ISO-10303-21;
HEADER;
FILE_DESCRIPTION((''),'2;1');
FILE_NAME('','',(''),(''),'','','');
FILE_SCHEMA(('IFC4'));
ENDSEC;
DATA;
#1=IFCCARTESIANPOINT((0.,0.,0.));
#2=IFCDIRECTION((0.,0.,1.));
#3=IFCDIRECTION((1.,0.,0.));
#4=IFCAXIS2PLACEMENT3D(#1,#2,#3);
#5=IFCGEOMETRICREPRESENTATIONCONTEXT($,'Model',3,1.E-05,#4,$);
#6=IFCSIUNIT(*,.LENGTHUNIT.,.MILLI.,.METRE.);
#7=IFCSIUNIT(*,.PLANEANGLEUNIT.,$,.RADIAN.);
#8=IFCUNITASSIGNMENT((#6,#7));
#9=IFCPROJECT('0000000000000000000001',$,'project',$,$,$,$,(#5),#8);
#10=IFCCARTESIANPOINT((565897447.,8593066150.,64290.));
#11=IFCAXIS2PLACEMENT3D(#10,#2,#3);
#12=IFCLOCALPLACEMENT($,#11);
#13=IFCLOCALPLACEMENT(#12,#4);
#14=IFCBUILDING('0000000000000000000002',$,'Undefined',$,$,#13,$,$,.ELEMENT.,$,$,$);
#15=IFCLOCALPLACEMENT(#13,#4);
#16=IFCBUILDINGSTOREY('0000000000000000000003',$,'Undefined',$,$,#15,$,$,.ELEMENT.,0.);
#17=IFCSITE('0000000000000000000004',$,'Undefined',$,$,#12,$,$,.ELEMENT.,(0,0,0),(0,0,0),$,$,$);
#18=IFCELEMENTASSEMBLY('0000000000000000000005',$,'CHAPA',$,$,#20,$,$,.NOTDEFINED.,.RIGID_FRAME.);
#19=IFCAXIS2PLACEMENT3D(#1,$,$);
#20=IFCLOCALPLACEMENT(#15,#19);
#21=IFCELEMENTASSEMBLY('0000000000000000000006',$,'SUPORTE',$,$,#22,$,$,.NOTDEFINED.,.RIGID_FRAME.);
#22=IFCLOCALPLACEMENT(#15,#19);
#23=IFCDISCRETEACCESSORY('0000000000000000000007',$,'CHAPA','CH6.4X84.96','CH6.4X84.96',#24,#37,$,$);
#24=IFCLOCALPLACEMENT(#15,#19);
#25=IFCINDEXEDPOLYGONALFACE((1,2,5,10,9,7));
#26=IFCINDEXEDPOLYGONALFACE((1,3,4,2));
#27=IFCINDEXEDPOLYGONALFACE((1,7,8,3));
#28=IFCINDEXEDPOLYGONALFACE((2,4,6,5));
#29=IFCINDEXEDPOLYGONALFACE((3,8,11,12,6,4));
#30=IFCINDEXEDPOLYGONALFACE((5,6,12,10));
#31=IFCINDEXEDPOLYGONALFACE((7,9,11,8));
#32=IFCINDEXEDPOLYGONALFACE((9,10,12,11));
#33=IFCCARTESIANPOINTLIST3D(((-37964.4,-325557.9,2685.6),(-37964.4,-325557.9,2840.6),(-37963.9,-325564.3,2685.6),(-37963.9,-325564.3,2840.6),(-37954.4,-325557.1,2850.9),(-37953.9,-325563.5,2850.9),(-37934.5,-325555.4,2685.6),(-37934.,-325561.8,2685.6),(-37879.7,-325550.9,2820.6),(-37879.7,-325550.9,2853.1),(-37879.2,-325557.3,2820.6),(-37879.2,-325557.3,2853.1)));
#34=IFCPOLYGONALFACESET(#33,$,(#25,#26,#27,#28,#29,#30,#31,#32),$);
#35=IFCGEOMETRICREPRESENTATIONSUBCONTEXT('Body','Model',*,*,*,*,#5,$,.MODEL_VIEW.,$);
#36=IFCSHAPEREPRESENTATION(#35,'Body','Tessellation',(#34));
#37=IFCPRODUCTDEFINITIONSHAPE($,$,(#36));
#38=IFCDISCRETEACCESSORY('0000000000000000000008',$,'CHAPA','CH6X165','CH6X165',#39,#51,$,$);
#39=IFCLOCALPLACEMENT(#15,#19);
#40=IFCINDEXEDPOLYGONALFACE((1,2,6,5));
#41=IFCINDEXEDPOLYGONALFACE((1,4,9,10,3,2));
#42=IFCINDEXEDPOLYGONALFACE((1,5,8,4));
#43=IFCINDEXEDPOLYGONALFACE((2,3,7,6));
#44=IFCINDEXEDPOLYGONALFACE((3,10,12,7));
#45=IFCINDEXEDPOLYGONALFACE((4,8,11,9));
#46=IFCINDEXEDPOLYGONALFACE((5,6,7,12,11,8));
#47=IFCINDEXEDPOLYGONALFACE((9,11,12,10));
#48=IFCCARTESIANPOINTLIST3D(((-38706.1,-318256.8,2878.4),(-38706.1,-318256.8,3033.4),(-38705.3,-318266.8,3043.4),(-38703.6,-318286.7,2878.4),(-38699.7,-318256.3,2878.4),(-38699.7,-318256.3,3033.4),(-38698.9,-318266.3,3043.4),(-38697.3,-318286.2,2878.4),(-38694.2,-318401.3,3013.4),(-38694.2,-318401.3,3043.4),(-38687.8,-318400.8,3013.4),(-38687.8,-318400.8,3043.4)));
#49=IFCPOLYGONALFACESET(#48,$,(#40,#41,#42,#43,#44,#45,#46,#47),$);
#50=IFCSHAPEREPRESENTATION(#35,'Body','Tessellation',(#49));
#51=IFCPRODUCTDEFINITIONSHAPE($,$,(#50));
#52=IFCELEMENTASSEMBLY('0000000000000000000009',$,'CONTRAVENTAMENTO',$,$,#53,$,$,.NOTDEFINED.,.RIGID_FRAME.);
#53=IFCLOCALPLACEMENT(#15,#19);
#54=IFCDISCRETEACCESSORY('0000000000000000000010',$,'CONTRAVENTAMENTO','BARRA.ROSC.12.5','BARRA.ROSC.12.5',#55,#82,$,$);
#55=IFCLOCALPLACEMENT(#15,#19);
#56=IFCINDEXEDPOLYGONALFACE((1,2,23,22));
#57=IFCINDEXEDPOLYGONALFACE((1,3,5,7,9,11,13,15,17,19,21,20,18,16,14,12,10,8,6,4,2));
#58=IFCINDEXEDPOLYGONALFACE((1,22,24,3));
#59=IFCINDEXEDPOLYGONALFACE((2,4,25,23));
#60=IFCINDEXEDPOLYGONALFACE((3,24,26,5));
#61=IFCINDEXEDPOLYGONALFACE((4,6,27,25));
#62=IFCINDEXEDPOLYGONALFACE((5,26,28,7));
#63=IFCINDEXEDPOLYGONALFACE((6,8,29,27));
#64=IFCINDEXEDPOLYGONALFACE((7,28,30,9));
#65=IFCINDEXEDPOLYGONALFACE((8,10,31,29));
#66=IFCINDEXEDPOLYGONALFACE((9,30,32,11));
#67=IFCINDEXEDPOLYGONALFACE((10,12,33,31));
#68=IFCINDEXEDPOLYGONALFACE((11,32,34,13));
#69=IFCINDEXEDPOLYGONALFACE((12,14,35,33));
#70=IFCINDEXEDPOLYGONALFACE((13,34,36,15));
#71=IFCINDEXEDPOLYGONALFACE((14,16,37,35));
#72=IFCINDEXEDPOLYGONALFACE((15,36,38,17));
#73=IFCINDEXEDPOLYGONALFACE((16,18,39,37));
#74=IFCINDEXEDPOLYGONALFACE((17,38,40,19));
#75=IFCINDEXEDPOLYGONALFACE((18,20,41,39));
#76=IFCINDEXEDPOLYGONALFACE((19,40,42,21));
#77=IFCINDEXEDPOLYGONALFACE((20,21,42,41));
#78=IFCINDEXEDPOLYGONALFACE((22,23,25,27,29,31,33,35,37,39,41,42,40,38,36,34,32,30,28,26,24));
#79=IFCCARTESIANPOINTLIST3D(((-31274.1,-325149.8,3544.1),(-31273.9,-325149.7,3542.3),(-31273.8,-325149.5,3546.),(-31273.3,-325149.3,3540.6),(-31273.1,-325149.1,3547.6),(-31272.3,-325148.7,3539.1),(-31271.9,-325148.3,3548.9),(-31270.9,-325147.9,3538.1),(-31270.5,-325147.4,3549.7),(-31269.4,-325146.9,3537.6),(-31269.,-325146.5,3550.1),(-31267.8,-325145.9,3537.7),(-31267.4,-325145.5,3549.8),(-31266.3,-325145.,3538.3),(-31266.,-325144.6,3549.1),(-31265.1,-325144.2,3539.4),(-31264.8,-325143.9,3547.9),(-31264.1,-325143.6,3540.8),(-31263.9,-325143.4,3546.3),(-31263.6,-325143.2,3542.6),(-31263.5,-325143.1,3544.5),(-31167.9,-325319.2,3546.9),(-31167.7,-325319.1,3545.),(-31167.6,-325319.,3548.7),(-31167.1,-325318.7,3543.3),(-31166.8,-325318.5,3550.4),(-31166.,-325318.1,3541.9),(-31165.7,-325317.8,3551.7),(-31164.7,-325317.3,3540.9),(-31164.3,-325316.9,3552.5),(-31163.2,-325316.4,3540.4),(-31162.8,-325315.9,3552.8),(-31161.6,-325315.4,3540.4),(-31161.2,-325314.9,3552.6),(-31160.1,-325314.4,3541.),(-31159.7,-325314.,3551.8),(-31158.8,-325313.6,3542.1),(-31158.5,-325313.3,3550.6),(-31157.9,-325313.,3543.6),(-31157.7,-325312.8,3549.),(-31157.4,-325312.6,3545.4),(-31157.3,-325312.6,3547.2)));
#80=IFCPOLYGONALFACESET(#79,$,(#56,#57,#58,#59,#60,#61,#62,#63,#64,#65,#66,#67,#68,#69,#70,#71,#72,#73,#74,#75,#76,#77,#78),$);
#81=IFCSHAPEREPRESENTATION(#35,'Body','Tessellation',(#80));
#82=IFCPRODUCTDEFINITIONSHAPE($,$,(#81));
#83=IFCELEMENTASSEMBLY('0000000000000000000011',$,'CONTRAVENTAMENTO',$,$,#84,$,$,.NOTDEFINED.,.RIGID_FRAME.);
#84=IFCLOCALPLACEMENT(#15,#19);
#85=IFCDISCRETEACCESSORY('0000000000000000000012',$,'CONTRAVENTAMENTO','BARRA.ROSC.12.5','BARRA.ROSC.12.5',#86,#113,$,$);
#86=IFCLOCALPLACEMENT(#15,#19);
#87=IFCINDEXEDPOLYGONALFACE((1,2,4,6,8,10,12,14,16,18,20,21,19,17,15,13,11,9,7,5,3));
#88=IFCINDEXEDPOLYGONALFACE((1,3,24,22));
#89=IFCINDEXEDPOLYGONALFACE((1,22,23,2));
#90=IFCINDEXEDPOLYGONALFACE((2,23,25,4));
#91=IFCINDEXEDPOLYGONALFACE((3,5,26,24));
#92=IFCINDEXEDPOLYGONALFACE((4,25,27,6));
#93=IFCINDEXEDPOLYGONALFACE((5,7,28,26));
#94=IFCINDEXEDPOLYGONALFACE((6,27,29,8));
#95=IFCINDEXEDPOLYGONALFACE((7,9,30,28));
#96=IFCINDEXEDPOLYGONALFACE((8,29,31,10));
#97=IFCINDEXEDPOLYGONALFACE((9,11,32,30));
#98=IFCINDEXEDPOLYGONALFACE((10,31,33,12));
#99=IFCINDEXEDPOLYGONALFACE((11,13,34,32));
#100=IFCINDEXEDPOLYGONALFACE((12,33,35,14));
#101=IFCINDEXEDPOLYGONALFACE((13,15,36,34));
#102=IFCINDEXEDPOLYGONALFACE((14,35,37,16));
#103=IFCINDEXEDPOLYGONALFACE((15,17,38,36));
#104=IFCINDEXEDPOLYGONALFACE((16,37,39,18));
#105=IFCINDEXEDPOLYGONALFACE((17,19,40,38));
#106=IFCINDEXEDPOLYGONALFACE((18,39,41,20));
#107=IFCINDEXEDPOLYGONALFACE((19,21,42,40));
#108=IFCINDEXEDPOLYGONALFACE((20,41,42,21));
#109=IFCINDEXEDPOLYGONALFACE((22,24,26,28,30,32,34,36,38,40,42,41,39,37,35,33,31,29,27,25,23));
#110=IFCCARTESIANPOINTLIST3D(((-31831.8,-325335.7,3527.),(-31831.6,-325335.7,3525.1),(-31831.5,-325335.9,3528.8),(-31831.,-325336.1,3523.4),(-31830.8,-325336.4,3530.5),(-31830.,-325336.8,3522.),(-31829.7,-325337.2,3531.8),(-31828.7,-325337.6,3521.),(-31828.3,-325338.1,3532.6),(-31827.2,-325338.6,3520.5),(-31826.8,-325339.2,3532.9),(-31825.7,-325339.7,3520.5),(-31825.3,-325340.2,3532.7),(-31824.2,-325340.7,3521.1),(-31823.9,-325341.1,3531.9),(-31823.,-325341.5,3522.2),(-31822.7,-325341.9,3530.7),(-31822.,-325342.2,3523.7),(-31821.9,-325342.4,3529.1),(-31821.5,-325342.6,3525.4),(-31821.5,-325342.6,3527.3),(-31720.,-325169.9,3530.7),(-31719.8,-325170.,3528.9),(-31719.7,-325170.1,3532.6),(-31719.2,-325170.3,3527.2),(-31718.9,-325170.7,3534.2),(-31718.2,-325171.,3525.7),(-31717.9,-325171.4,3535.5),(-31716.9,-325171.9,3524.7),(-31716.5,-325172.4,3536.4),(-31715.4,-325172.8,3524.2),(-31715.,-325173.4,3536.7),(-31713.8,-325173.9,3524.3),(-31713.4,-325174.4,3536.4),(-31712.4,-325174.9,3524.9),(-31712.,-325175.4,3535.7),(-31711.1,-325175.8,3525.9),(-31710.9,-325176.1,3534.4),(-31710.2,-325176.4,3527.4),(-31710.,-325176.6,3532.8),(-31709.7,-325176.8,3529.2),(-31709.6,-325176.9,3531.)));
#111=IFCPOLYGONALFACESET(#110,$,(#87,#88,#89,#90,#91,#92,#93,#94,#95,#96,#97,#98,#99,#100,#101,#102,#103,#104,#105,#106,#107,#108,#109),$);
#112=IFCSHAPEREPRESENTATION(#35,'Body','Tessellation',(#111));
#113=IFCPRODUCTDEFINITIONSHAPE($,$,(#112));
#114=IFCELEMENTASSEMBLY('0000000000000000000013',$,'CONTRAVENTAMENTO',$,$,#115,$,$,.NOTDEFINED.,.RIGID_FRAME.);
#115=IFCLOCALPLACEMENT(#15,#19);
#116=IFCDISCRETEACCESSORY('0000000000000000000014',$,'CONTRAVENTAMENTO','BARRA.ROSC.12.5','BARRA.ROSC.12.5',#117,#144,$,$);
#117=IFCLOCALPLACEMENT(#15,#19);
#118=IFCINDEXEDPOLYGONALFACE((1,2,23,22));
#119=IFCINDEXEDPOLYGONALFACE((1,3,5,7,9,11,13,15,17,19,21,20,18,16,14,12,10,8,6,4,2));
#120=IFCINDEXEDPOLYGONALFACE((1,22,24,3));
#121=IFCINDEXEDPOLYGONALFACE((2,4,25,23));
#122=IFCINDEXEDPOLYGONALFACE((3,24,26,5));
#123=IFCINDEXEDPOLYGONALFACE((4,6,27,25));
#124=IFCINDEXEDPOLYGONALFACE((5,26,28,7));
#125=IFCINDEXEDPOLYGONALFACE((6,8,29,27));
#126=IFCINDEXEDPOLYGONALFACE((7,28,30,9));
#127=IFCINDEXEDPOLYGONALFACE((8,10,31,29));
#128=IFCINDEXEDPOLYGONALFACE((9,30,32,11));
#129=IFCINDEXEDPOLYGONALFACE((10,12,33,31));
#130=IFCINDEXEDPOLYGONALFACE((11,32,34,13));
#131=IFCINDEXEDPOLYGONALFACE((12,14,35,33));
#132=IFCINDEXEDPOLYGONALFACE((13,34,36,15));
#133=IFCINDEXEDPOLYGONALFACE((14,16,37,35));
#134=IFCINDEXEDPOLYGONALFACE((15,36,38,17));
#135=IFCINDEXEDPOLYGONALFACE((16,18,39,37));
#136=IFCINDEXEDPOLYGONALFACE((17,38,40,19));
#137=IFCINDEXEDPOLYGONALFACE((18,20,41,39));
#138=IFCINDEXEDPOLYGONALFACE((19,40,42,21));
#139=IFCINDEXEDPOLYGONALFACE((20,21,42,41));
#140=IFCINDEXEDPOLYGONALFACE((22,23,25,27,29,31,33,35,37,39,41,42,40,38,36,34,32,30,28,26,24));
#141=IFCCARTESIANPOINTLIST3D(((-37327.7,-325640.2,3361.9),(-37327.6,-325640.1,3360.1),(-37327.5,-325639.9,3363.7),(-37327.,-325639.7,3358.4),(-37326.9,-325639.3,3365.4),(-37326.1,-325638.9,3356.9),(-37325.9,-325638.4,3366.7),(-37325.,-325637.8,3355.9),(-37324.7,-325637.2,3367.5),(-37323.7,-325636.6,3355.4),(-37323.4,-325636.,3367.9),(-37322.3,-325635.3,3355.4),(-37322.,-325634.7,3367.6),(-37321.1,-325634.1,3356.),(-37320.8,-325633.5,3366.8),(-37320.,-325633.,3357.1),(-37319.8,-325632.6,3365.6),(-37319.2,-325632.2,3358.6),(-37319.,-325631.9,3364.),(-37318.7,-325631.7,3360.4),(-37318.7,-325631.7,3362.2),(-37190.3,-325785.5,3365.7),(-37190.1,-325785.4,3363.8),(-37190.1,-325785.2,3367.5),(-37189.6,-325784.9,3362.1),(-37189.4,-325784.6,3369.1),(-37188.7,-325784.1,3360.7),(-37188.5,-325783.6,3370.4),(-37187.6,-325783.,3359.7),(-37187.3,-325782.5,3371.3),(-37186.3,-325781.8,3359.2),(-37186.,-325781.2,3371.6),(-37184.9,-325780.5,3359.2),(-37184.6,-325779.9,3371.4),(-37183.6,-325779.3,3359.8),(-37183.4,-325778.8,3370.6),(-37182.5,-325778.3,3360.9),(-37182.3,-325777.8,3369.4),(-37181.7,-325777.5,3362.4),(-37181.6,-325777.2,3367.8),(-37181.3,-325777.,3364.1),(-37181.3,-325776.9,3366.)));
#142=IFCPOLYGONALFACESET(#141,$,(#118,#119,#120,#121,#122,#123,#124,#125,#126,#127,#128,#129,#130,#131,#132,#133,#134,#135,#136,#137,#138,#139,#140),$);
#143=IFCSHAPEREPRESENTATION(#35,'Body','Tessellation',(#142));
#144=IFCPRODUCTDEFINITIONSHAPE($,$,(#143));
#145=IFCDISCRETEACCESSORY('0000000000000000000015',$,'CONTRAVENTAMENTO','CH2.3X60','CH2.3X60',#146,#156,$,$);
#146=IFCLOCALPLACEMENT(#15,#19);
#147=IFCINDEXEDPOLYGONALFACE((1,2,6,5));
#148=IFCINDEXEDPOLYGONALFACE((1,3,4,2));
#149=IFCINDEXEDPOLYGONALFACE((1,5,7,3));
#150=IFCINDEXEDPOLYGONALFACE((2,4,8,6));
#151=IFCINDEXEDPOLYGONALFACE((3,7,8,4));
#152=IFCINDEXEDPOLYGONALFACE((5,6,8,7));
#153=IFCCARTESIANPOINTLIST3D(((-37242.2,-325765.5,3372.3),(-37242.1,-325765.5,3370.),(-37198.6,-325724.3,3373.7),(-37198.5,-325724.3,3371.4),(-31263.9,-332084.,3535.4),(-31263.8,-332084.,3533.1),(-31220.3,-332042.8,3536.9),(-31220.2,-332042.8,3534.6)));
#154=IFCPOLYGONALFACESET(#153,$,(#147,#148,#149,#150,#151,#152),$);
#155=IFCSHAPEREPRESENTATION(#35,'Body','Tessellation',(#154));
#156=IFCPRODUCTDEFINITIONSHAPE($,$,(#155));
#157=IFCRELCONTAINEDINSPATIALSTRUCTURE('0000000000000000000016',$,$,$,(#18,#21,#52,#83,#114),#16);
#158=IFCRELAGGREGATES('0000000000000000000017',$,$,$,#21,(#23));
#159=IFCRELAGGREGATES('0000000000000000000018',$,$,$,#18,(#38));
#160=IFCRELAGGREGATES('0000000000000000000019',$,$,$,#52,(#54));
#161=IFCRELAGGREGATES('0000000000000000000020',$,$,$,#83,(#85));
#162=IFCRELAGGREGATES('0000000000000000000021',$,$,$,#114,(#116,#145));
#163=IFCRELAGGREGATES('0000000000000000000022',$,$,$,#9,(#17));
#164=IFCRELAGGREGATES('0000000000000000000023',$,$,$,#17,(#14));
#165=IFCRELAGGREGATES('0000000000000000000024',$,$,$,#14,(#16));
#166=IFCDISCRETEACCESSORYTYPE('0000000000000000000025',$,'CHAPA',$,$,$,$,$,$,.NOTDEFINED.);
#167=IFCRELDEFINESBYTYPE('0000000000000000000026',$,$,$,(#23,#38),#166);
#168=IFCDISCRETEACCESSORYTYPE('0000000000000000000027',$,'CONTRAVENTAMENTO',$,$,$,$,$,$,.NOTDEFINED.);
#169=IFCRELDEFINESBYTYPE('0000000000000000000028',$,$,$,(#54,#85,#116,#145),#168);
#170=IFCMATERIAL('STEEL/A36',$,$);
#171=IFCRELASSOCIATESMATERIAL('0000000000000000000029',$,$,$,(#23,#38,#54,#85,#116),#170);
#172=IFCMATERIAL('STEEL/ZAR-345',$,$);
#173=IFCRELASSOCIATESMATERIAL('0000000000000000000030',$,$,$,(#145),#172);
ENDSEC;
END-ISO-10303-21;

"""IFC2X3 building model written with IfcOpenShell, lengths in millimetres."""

from ifc_helpers import new_model, si_unit, frame, origin_with_axes, origin_2d_with_axis, place, context, subcontext, project, spatial, polyline, circle, outline, extrude, material, type_object, element, aggregate, save


model = new_model("IFC2X3")

# Units and contexts
model_context = context("Model", 3, precision=1e-05, world=origin_with_axes())
body_context = subcontext(model_context, "Body", "Model", "MODEL_VIEW")
ifc_project = project(units=[si_unit("LENGTHUNIT", "METRE", prefix="MILLI"), si_unit("PLANEANGLEUNIT", "RADIAN")], contexts=[model_context])

# Site, building, storey
site_placement = place(None, frame((565897447.0, 8593066150.0, 64290.0), z_axis=(0.0, 0.0, 1.0), x_axis=(1.0, 0.0, 0.0)))
site = spatial("IfcSite", under=ifc_project, at=site_placement, Name="Undefined", CompositionType="ELEMENT", RefLatitude=(0, 0, 0), RefLongitude=(0, 0, 0))
building_placement = place(site_placement, origin_with_axes())
building = spatial("IfcBuilding", under=site, at=building_placement, Name="Undefined", CompositionType="ELEMENT")
storey_placement = place(building_placement, origin_with_axes())
storey = spatial("IfcBuildingStorey", under=building, at=storey_placement, Name="Undefined", CompositionType="ELEMENT", Elevation=0.0)

# Element assembly
ifc_material_1 = material(Name="STEEL/A36")
assembly_1_placement = place(storey_placement, origin_with_axes())
assembly_1 = element("IfcElementAssembly", 1, at=assembly_1_placement, inside=storey, Name="CHAPA", AssemblyPlace="NOTDEFINED", PredefinedType="RIGID_FRAME")

# Shared definitions
discrete_accessory_type_1 = type_object("IfcDiscreteAccessoryType", Name="CHAPA")

# Element assembly, discrete accessory
assembly_2_placement = place(storey_placement, origin_with_axes())
assembly_2 = element("IfcElementAssembly", 2, at=assembly_2_placement, inside=storey, Name="SUPORTE", AssemblyPlace="NOTDEFINED", PredefinedType="RIGID_FRAME")
discrete_accessory_1_placement = place(assembly_2_placement, frame((-37964.1, -325561.1, 2850.6), z_axis=(0.082025, -0.99663, 0.0), x_axis=(0.0, 0.0, -1.0)))
discrete_accessory_1 = element("IfcDiscreteAccessory", 3, at=discrete_accessory_1_placement, type_object=discrete_accessory_type_1, material=ifc_material_1, Name="CHAPA", Description="CH6.4X84.96", ObjectType="CH6.4X84.96", context=body_context, shape_type="SweptSolid", body=[
    extrude(outline(polyline([(-0.3, 10.0), (10.0, 0.0), (165.0, 0.0), (165.0, 30.0), (30.0, 85.0), (-2.5, 85.0), (-0.3, 10.0)])), frame((0.0, 0.0, -3.2), z_axis=(0.0, 0.0, 1.0), x_axis=(1.0, 0.0, 0.0)), (0.0, 0.0, 1.0), 6.4),
])
aggregate(assembly_2, [discrete_accessory_1])

# Discrete accessory
discrete_accessory_2_placement = place(assembly_1_placement, frame((-38702.9, -318256.6, 3043.4), z_axis=(-0.99663, -0.082025, 0.000004), x_axis=(-0.000004, 0.0, -1.0)))
discrete_accessory_2 = element("IfcDiscreteAccessory", 4, at=discrete_accessory_2_placement, type_object=discrete_accessory_type_1, material=ifc_material_1, Name="CHAPA", Description="CH6X165", ObjectType="CH6X165", context=body_context, shape_type="SweptSolid", body=[
    extrude(outline(polyline([(0.0, 10.0), (10.0, 0.0), (165.0, 0.0), (165.0, 30.0), (30.0, 145.0), (0.0, 145.0), (0.0, 10.0)])), frame((0.0, 0.0, -3.2), z_axis=(0.0, 0.0, 1.0), x_axis=(1.0, 0.0, 0.0)), (0.0, 0.0, 1.0), 6.4),
])
aggregate(assembly_1, [discrete_accessory_2])

# Element assemblies, discrete accessories
assembly_3_placement = place(storey_placement, origin_with_axes())
assembly_3 = element("IfcElementAssembly", 5, at=assembly_3_placement, inside=storey, Name="CONTRAVENTAMENTO", AssemblyPlace="NOTDEFINED", PredefinedType="RIGID_FRAME")
discrete_accessory_type_2 = type_object("IfcDiscreteAccessoryType", Name="CONTRAVENTAMENTO")
discrete_accessory_3_placement = place(assembly_3_placement, frame((-31268.8, -325146.4, 3543.8), z_axis=(0.84672, 0.531363, 0.026799), x_axis=(0.53119, -0.84714, 0.013797)))
discrete_accessory_3 = element("IfcDiscreteAccessory", 6, at=discrete_accessory_3_placement, type_object=discrete_accessory_type_2, material=ifc_material_1, Name="CONTRAVENTAMENTO", Description="BARRA.ROSC.12.5", ObjectType="BARRA.ROSC.12.5", context=body_context, shape_type="SweptSolid", body=[
    extrude(circle(Radius=6.2, at=origin_2d_with_axis()), frame((200.0, 0.0, 0.0), z_axis=(-1.0, 0.0, 0.0), x_axis=(0.0, -1.0, 0.0)), (0.0, 0.0, 1.0), 200.0),
])
aggregate(assembly_3, [discrete_accessory_3])
assembly_4_placement = place(storey_placement, origin_with_axes())
assembly_4 = element("IfcElementAssembly", 7, at=assembly_4_placement, inside=storey, Name="CONTRAVENTAMENTO", AssemblyPlace="NOTDEFINED", PredefinedType="RIGID_FRAME")
discrete_accessory_4_placement = place(assembly_4_placement, frame((-31714.8, -325173.4, 3530.4), z_axis=(0.828505, -0.559481, 0.023679), x_axis=(-0.559171, -0.82884, -0.018758)))
discrete_accessory_4 = element("IfcDiscreteAccessory", 8, at=discrete_accessory_4_placement, type_object=discrete_accessory_type_2, material=ifc_material_1, Name="CONTRAVENTAMENTO", Description="BARRA.ROSC.12.5", ObjectType="BARRA.ROSC.12.5", context=body_context, shape_type="SweptSolid", body=[
    extrude(circle(Radius=6.2, at=origin_2d_with_axis()), frame((200.0, 0.0, 0.0), z_axis=(-1.0, 0.0, 0.0), x_axis=(0.0, -1.0, 0.0)), (0.0, 0.0, 1.0), 200.0),
])
aggregate(assembly_4, [discrete_accessory_4])

# Element assembly, discrete accessories
assembly_5_placement = place(storey_placement, origin_with_axes())
assembly_5 = element("IfcElementAssembly", 9, at=assembly_5_placement, inside=storey, Name="CONTRAVENTAMENTO", AssemblyPlace="NOTDEFINED", PredefinedType="RIGID_FRAME")
discrete_accessory_5_placement = place(assembly_5_placement, frame((-37323.2, -325635.9, 3361.6), z_axis=(0.725882, 0.687412, 0.023679), x_axis=(0.687161, -0.726263, 0.018758)))
discrete_accessory_5 = element("IfcDiscreteAccessory", 10, at=discrete_accessory_5_placement, type_object=discrete_accessory_type_2, material=ifc_material_1, Name="CONTRAVENTAMENTO", Description="BARRA.ROSC.12.5", ObjectType="BARRA.ROSC.12.5", context=body_context, shape_type="SweptSolid", body=[
    extrude(circle(Radius=6.2, at=origin_2d_with_axis()), frame((200.0, 0.0, 0.0), z_axis=(-1.0, 0.0, 0.0), x_axis=(0.0, -1.0, 0.0)), (0.0, 0.0, 1.0), 200.0),
])
ifc_material_2 = material(Name="STEEL/ZAR-345")
discrete_accessory_6_placement = place(assembly_5_placement, frame((-37220.3, -325744.9, 3371.8), z_axis=(-0.030092, -0.002655, 0.999544), x_axis=(0.687161, -0.726263, 0.018758)))
discrete_accessory_6 = element("IfcDiscreteAccessory", 11, at=discrete_accessory_6_placement, type_object=discrete_accessory_type_2, material=ifc_material_2, Name="CONTRAVENTAMENTO", Description="CH2.3X60", ObjectType="CH2.3X60", context=body_context, shape_type="SweptSolid", body=[
    extrude(outline(polyline([(0.0, 30.0), (8700.0, 30.0), (8700.0, -30.0), (0.0, -30.0), (0.0, 30.0)])), frame((0.0, 0.0, -1.1), z_axis=(0.0, 0.0, 1.0), x_axis=(1.0, 0.0, 0.0)), (0.0, 0.0, 1.0), 2.3),
])
aggregate(assembly_5, [discrete_accessory_5, discrete_accessory_6])

save(model, "model.ifc")
